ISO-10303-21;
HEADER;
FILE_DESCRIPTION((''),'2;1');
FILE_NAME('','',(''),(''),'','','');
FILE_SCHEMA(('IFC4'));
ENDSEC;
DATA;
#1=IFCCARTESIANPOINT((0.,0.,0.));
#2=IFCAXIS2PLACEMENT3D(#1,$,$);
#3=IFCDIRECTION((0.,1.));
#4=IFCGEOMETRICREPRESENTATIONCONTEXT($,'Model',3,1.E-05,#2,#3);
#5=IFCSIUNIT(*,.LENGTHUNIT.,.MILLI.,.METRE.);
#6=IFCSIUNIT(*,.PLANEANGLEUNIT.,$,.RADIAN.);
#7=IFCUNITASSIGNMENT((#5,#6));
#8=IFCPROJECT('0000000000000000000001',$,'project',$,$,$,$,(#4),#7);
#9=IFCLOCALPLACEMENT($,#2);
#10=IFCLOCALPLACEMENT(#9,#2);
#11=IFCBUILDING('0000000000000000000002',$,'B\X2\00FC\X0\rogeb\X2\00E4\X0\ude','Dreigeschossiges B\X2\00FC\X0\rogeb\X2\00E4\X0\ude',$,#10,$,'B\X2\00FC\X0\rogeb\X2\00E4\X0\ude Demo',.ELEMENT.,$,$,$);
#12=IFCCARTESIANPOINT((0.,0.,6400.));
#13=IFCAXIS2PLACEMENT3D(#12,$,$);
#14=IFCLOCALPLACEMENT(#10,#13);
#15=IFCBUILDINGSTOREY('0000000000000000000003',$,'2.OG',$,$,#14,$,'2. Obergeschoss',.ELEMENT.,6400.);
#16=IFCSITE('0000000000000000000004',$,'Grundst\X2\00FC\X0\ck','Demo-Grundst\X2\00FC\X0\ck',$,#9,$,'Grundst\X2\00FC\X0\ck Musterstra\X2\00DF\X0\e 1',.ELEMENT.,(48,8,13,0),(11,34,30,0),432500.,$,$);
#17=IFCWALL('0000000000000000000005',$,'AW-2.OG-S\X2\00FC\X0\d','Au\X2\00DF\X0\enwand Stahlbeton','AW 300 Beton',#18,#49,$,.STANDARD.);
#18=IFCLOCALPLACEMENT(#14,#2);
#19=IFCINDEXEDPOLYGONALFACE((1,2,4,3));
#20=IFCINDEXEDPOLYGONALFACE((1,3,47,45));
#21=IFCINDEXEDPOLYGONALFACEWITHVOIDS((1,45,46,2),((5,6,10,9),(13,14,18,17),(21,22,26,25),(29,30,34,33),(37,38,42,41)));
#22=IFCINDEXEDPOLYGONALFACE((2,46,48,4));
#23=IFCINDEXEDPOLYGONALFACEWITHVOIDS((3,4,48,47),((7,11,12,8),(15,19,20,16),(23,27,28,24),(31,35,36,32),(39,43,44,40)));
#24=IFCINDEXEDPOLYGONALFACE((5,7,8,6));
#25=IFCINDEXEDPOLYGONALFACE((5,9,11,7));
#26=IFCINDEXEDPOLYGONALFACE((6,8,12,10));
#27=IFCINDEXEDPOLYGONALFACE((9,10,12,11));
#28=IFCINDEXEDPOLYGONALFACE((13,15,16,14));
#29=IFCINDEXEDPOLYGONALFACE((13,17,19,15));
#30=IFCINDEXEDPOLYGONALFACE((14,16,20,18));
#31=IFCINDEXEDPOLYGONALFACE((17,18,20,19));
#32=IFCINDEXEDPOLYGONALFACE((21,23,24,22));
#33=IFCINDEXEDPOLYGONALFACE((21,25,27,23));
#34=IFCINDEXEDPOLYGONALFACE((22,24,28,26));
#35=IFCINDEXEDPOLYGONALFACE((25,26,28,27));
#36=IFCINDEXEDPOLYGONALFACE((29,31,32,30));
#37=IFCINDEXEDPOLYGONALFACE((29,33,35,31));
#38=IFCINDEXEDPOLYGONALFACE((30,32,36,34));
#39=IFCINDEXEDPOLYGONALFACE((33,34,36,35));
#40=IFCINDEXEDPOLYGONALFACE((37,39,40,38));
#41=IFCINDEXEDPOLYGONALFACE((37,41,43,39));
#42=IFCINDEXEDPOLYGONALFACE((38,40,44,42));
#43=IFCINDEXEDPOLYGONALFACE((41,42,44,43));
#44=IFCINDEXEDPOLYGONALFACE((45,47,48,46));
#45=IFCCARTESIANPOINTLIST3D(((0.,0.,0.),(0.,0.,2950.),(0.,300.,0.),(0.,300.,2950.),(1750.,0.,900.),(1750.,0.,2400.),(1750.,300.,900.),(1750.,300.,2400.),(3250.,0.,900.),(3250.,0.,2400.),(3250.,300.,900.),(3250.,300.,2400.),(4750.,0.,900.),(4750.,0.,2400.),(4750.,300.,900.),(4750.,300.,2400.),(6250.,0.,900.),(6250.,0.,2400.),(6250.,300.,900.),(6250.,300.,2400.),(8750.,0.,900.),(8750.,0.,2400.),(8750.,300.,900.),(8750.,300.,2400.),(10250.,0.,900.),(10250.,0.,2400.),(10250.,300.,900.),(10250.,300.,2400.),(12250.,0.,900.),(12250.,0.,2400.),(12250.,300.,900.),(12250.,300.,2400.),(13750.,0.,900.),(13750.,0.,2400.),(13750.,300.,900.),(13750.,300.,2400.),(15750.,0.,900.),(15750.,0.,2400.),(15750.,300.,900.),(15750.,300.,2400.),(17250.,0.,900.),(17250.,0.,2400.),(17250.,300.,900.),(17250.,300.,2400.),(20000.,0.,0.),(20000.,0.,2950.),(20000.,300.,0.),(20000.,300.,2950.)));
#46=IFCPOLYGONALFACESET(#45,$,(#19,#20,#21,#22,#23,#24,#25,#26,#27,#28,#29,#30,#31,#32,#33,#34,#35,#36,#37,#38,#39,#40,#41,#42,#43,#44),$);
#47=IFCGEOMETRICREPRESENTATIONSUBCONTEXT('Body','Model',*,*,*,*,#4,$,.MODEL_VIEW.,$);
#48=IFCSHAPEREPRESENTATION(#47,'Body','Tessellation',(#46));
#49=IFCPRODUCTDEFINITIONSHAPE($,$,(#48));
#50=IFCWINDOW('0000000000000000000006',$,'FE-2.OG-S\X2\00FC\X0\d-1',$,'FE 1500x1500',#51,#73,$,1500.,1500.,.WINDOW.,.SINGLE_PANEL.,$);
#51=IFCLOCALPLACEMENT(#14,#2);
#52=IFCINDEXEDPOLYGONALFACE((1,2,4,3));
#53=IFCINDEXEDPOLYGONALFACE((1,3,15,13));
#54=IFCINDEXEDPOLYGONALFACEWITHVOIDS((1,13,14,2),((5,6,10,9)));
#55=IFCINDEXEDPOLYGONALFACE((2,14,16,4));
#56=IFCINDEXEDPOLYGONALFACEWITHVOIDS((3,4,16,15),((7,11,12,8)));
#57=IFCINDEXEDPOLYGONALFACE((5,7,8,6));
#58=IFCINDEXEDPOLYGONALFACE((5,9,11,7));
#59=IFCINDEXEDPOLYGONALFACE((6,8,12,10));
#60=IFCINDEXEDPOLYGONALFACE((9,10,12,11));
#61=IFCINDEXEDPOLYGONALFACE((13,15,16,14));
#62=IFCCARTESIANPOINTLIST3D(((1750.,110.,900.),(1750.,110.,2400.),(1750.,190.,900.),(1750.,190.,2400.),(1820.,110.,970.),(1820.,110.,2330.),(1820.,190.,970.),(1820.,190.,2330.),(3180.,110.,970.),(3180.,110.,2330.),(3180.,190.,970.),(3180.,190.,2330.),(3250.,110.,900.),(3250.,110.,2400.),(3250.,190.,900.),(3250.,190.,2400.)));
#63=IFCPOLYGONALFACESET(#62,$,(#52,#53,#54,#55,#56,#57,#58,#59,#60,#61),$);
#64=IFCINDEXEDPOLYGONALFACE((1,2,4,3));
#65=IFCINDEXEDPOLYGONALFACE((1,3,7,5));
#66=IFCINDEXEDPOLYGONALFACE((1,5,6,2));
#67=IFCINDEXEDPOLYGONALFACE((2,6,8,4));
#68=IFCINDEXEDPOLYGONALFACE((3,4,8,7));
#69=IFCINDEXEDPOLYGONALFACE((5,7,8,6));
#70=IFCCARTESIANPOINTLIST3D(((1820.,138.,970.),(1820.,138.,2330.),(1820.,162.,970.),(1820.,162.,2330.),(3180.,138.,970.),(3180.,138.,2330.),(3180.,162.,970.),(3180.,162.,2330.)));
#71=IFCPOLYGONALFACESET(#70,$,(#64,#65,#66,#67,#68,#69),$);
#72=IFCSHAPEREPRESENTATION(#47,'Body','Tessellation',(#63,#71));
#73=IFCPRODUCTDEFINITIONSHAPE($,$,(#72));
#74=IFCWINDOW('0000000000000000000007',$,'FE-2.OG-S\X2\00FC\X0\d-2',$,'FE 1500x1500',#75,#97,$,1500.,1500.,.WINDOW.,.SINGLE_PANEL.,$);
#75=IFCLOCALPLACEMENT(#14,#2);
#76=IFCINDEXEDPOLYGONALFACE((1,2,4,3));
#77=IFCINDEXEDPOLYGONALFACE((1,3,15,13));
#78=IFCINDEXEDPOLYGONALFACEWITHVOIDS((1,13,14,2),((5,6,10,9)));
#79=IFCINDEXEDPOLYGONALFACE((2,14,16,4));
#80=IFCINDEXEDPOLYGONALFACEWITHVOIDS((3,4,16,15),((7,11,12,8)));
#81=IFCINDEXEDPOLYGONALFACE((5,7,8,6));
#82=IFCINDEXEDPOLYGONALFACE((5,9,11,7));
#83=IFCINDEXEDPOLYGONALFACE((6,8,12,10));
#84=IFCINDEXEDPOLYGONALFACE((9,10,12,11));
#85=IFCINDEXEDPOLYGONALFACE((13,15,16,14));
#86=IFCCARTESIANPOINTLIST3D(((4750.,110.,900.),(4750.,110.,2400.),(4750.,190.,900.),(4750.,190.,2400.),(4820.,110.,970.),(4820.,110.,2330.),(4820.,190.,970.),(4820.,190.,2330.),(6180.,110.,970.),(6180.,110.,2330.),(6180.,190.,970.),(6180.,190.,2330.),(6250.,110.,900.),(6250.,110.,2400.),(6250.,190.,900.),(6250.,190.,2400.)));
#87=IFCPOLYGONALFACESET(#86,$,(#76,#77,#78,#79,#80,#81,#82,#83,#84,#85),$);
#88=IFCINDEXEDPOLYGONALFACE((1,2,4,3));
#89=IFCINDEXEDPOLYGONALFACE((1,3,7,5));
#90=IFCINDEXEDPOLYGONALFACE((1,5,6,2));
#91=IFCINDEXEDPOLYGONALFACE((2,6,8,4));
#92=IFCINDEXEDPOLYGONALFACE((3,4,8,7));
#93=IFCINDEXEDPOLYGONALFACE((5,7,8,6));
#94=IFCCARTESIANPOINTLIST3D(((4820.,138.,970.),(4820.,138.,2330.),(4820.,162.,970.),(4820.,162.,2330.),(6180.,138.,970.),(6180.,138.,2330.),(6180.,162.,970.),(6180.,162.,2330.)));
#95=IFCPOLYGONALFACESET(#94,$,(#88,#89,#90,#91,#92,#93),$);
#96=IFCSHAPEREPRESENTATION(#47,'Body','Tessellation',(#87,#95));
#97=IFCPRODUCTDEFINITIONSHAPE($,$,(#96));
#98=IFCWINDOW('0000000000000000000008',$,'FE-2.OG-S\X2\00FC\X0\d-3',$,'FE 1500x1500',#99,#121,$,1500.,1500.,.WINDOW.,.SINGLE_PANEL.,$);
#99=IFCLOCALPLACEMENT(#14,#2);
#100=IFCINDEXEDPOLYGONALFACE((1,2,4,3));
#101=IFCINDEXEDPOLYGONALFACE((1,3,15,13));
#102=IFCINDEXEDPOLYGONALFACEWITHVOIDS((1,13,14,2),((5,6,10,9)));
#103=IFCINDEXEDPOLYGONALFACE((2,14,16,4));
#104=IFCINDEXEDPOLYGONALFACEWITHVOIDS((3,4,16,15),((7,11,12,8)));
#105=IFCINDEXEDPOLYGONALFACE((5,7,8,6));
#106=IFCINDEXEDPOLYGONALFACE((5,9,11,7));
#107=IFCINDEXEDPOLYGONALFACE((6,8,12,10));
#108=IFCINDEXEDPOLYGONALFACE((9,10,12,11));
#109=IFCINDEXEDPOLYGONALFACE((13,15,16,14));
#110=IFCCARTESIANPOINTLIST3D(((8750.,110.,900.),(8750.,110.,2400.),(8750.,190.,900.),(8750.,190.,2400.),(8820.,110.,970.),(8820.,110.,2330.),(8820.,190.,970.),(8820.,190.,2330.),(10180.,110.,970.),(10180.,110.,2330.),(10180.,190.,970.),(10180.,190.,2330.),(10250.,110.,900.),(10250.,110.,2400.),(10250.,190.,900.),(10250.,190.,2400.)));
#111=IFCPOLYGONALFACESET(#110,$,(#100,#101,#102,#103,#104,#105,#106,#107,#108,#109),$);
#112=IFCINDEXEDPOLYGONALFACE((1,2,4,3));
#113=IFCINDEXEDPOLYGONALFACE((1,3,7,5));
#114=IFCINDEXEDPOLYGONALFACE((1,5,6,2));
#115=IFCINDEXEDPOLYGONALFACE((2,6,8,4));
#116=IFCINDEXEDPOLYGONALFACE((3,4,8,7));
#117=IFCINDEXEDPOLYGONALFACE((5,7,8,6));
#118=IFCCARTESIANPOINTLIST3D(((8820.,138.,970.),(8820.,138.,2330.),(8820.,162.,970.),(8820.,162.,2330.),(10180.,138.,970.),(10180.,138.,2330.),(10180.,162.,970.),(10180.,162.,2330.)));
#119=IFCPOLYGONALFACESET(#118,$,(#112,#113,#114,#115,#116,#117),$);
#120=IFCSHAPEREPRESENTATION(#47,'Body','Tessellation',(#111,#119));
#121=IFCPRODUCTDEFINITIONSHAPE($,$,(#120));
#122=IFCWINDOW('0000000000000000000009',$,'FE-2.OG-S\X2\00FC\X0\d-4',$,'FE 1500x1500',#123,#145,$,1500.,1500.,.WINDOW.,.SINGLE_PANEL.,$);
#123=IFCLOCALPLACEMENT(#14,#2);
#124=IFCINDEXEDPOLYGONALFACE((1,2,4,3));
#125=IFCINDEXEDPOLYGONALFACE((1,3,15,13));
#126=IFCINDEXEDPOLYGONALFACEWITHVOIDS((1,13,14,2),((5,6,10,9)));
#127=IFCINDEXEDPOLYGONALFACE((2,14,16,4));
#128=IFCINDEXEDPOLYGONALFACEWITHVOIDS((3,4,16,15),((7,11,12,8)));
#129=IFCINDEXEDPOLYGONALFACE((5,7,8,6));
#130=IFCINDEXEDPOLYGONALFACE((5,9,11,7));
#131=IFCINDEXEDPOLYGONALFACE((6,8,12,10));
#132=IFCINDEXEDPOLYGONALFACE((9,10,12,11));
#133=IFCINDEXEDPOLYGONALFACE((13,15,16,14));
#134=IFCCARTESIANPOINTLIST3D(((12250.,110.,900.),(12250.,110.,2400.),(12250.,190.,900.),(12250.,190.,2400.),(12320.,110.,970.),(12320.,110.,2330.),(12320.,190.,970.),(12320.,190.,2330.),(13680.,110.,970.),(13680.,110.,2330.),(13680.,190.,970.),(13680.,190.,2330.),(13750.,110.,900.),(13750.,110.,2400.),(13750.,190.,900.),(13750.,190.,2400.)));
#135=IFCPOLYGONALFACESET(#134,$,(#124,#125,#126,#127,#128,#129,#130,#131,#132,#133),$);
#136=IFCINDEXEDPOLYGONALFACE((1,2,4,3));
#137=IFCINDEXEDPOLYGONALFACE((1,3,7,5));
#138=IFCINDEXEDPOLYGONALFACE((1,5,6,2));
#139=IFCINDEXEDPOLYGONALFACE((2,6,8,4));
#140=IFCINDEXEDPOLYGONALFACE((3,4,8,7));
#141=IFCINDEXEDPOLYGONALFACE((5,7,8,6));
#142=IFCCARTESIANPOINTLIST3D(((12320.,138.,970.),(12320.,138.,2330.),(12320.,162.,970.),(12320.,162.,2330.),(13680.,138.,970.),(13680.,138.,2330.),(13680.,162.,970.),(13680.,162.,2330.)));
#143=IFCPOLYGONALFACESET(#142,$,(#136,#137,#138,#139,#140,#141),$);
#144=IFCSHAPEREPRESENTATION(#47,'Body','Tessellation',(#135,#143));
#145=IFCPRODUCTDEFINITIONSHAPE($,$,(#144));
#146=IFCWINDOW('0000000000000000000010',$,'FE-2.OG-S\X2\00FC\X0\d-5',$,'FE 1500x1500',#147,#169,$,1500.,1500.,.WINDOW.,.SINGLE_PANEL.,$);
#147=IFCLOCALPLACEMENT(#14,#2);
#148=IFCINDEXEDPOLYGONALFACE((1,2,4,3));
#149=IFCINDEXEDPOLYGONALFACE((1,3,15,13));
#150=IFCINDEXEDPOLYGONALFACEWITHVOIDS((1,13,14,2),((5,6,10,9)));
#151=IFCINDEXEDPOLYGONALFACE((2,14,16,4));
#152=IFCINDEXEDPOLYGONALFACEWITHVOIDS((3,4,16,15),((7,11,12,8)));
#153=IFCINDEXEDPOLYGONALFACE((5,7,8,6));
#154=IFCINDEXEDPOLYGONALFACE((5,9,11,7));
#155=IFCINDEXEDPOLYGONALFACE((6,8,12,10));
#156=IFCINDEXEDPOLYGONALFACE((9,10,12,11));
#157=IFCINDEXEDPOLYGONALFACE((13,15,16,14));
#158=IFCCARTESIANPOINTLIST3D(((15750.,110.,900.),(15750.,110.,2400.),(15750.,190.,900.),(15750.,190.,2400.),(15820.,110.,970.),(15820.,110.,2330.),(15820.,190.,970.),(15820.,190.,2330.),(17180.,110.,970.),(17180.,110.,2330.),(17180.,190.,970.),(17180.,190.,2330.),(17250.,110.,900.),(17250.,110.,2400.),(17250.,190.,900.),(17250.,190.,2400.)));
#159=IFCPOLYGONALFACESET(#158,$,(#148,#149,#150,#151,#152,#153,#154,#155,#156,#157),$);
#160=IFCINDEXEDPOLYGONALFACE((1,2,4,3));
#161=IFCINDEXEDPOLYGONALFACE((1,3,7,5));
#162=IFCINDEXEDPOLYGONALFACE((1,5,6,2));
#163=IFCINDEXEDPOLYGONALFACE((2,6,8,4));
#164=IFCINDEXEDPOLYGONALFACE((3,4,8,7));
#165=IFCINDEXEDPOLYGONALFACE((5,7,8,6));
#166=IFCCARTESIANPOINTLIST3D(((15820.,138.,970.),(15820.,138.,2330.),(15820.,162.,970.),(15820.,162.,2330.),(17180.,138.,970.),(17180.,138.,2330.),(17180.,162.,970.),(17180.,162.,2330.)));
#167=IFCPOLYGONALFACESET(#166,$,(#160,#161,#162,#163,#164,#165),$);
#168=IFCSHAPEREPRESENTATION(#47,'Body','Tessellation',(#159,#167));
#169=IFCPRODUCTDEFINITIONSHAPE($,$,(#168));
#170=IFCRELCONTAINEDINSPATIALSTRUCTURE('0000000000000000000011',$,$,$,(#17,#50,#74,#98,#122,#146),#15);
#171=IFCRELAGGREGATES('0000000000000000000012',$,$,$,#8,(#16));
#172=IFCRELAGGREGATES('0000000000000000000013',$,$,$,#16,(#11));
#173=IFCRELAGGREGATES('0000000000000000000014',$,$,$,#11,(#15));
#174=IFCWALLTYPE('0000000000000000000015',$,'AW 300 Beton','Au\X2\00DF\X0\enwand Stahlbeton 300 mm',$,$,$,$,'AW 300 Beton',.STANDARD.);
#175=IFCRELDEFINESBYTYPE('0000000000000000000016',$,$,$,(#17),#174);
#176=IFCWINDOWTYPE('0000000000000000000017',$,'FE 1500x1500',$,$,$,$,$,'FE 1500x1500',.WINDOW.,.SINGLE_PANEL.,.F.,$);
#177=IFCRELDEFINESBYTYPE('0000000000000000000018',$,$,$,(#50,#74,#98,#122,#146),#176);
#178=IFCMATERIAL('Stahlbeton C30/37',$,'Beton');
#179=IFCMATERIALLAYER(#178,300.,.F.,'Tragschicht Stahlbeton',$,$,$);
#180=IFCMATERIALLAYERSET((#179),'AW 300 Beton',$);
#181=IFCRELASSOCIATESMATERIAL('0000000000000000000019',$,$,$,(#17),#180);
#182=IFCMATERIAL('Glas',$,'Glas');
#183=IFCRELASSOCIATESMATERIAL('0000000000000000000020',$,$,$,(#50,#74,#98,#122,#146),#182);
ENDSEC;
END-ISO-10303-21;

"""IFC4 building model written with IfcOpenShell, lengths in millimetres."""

from ifc_helpers import new_model, si_unit, direction, frame, frame_2d, origin, origin_2d, place, context, subcontext, project, spatial, polyline, rectangle, outline, extrude, material, layer, layer_set, layer_usage, type_object, element, fill, save


model = new_model("IFC4")

# Units and contexts
model_context = context("Model", 3, precision=1e-05, world=origin(), true_north=direction((0.0, 1.0)))
body_context = subcontext(model_context, "Body", "Model", "MODEL_VIEW")
ifc_project = project(units=[si_unit("LENGTHUNIT", "METRE", prefix="MILLI"), si_unit("PLANEANGLEUNIT", "RADIAN")], contexts=[model_context])

# Site, building, storey
site_placement = place(None, origin())
site = spatial("IfcSite", under=ifc_project, at=site_placement, Name="Grundstück", Description="Demo-Grundstück", LongName="Grundstück Musterstraße 1", CompositionType="ELEMENT", RefLatitude=(48, 8, 13, 0), RefLongitude=(11, 34, 30, 0), RefElevation=432500.0)
building_placement = place(site_placement, origin())
building = spatial("IfcBuilding", under=site, at=building_placement, Name="Bürogebäude", Description="Dreigeschossiges Bürogebäude", LongName="Bürogebäude Demo", CompositionType="ELEMENT")
storey_placement = place(building_placement, frame((0.0, 0.0, 6400.0)))
storey = spatial("IfcBuildingStorey", under=building, at=storey_placement, Name="2.OG", LongName="2. Obergeschoss", CompositionType="ELEMENT", Elevation=6400.0)

# Shared definitions
ifc_material_1 = material(Name="Stahlbeton C30/37", Category="Beton")

# Wall, openings, windows
ifc_layer = layer(ifc_material_1, 300.0, ventilated=False, Name="Tragschicht Stahlbeton")
ifc_layer_set = layer_set([ifc_layer], Name="AW 300 Beton")
ifc_layer_usage = layer_usage(ifc_layer_set, "AXIS2", "POSITIVE", -150.0)
wall_type = type_object("IfcWallType", Name="AW 300 Beton", Description="Außenwand Stahlbeton 300 mm", ElementType="AW 300 Beton", PredefinedType="STANDARD")
wall_1_placement = place(storey_placement, frame((0.0, 150.0, 0.0)))
wall_1 = element("IfcWall", 1, at=wall_1_placement, inside=storey, type_object=wall_type, material=ifc_layer_usage, Name="AW-2.OG-Süd", Description="Außenwand Stahlbeton", ObjectType="AW 300 Beton", PredefinedType="STANDARD", context=body_context, shape_type="SweptSolid", body=[
    extrude(rectangle(XDim=20000.0, YDim=300.0, at=frame_2d((10000.0, 0.0))), origin(), (0.0, 0.0, 1.0), 2950.0),
])
opening_1_placement = place(wall_1_placement, frame((2500.0, 0.0, 900.0)))
opening_1 = element("IfcOpeningElement", 2, at=opening_1_placement, cuts=wall_1, PredefinedType="OPENING", context=body_context, shape_type="SweptSolid", body=[
    extrude(rectangle(XDim=1500.0, YDim=340.0, at=origin_2d()), origin(), (0.0, 0.0, 1.0), 1500.0),
])
opening_2_placement = place(wall_1_placement, frame((5500.0, 0.0, 900.0)))
opening_2 = element("IfcOpeningElement", 3, at=opening_2_placement, cuts=wall_1, PredefinedType="OPENING", context=body_context, shape_type="SweptSolid", body=[
    extrude(rectangle(XDim=1500.0, YDim=340.0, at=origin_2d()), origin(), (0.0, 0.0, 1.0), 1500.0),
])
opening_3_placement = place(wall_1_placement, frame((9500.0, 0.0, 900.0)))
opening_3 = element("IfcOpeningElement", 4, at=opening_3_placement, cuts=wall_1, PredefinedType="OPENING", context=body_context, shape_type="SweptSolid", body=[
    extrude(rectangle(XDim=1500.0, YDim=340.0, at=origin_2d()), origin(), (0.0, 0.0, 1.0), 1500.0),
])
opening_4_placement = place(wall_1_placement, frame((13000.0, 0.0, 900.0)))
opening_4 = element("IfcOpeningElement", 5, at=opening_4_placement, cuts=wall_1, PredefinedType="OPENING", context=body_context, shape_type="SweptSolid", body=[
    extrude(rectangle(XDim=1500.0, YDim=340.0, at=origin_2d()), origin(), (0.0, 0.0, 1.0), 1500.0),
])
opening_5_placement = place(wall_1_placement, frame((16500.0, 0.0, 900.0)))
opening_5 = element("IfcOpeningElement", 6, at=opening_5_placement, cuts=wall_1, PredefinedType="OPENING", context=body_context, shape_type="SweptSolid", body=[
    extrude(rectangle(XDim=1500.0, YDim=340.0, at=origin_2d()), origin(), (0.0, 0.0, 1.0), 1500.0),
])
ifc_material_2 = material(Name="Glas", Category="Glas")
window_type = type_object("IfcWindowType", Name="FE 1500x1500", ElementType="FE 1500x1500", ParameterTakesPrecedence=False, PartitioningType="SINGLE_PANEL", PredefinedType="WINDOW")
window_1_placement = place(opening_1_placement, origin())
window_1 = element("IfcWindow", 7, at=window_1_placement, inside=storey, type_object=window_type, material=ifc_material_2, Name="FE-2.OG-Süd-1", ObjectType="FE 1500x1500", OverallHeight=1500.0, OverallWidth=1500.0, PartitioningType="SINGLE_PANEL", PredefinedType="WINDOW", context=body_context, shape_type="SweptSolid", body=[
    extrude(outline(polyline([(-750.0, 0.0), (750.0, 0.0), (750.0, 1500.0), (-750.0, 1500.0), (-750.0, 0.0)]), holes=[polyline([(-680.0, 70.0), (680.0, 70.0), (680.0, 1430.0), (-680.0, 1430.0), (-680.0, 70.0)])]), frame((0.0, 40.0, 0.0), z_axis=(0.0, -1.0, 0.0), x_axis=(1.0, 0.0, 0.0)), (0.0, 0.0, 1.0), 80.0),
    extrude(rectangle(XDim=1360.0, YDim=24.0, at=origin_2d()), frame((0.0, 0.0, 70.0)), (0.0, 0.0, 1.0), 1360.0),
])
fill(opening_1, window_1)
window_2_placement = place(opening_2_placement, origin())
window_2 = element("IfcWindow", 8, at=window_2_placement, inside=storey, type_object=window_type, material=ifc_material_2, Name="FE-2.OG-Süd-2", ObjectType="FE 1500x1500", OverallHeight=1500.0, OverallWidth=1500.0, PartitioningType="SINGLE_PANEL", PredefinedType="WINDOW", context=body_context, shape_type="SweptSolid", body=[
    extrude(outline(polyline([(-750.0, 0.0), (750.0, 0.0), (750.0, 1500.0), (-750.0, 1500.0), (-750.0, 0.0)]), holes=[polyline([(-680.0, 70.0), (680.0, 70.0), (680.0, 1430.0), (-680.0, 1430.0), (-680.0, 70.0)])]), frame((0.0, 40.0, 0.0), z_axis=(0.0, -1.0, 0.0), x_axis=(1.0, 0.0, 0.0)), (0.0, 0.0, 1.0), 80.0),
    extrude(rectangle(XDim=1360.0, YDim=24.0, at=origin_2d()), frame((0.0, 0.0, 70.0)), (0.0, 0.0, 1.0), 1360.0),
])
fill(opening_2, window_2)
window_3_placement = place(opening_3_placement, origin())
window_3 = element("IfcWindow", 9, at=window_3_placement, inside=storey, type_object=window_type, material=ifc_material_2, Name="FE-2.OG-Süd-3", ObjectType="FE 1500x1500", OverallHeight=1500.0, OverallWidth=1500.0, PartitioningType="SINGLE_PANEL", PredefinedType="WINDOW", context=body_context, shape_type="SweptSolid", body=[
    extrude(outline(polyline([(-750.0, 0.0), (750.0, 0.0), (750.0, 1500.0), (-750.0, 1500.0), (-750.0, 0.0)]), holes=[polyline([(-680.0, 70.0), (680.0, 70.0), (680.0, 1430.0), (-680.0, 1430.0), (-680.0, 70.0)])]), frame((0.0, 40.0, 0.0), z_axis=(0.0, -1.0, 0.0), x_axis=(1.0, 0.0, 0.0)), (0.0, 0.0, 1.0), 80.0),
    extrude(rectangle(XDim=1360.0, YDim=24.0, at=origin_2d()), frame((0.0, 0.0, 70.0)), (0.0, 0.0, 1.0), 1360.0),
])
fill(opening_3, window_3)
window_4_placement = place(opening_4_placement, origin())
window_4 = element("IfcWindow", 10, at=window_4_placement, inside=storey, type_object=window_type, material=ifc_material_2, Name="FE-2.OG-Süd-4", ObjectType="FE 1500x1500", OverallHeight=1500.0, OverallWidth=1500.0, PartitioningType="SINGLE_PANEL", PredefinedType="WINDOW", context=body_context, shape_type="SweptSolid", body=[
    extrude(outline(polyline([(-750.0, 0.0), (750.0, 0.0), (750.0, 1500.0), (-750.0, 1500.0), (-750.0, 0.0)]), holes=[polyline([(-680.0, 70.0), (680.0, 70.0), (680.0, 1430.0), (-680.0, 1430.0), (-680.0, 70.0)])]), frame((0.0, 40.0, 0.0), z_axis=(0.0, -1.0, 0.0), x_axis=(1.0, 0.0, 0.0)), (0.0, 0.0, 1.0), 80.0),
    extrude(rectangle(XDim=1360.0, YDim=24.0, at=origin_2d()), frame((0.0, 0.0, 70.0)), (0.0, 0.0, 1.0), 1360.0),
])
fill(opening_4, window_4)
window_5_placement = place(opening_5_placement, origin())
window_5 = element("IfcWindow", 11, at=window_5_placement, inside=storey, type_object=window_type, material=ifc_material_2, Name="FE-2.OG-Süd-5", ObjectType="FE 1500x1500", OverallHeight=1500.0, OverallWidth=1500.0, PartitioningType="SINGLE_PANEL", PredefinedType="WINDOW", context=body_context, shape_type="SweptSolid", body=[
    extrude(outline(polyline([(-750.0, 0.0), (750.0, 0.0), (750.0, 1500.0), (-750.0, 1500.0), (-750.0, 0.0)]), holes=[polyline([(-680.0, 70.0), (680.0, 70.0), (680.0, 1430.0), (-680.0, 1430.0), (-680.0, 70.0)])]), frame((0.0, 40.0, 0.0), z_axis=(0.0, -1.0, 0.0), x_axis=(1.0, 0.0, 0.0)), (0.0, 0.0, 1.0), 80.0),
    extrude(rectangle(XDim=1360.0, YDim=24.0, at=origin_2d()), frame((0.0, 0.0, 70.0)), (0.0, 0.0, 1.0), 1360.0),
])
fill(opening_5, window_5)

save(model, "model.ifc")
